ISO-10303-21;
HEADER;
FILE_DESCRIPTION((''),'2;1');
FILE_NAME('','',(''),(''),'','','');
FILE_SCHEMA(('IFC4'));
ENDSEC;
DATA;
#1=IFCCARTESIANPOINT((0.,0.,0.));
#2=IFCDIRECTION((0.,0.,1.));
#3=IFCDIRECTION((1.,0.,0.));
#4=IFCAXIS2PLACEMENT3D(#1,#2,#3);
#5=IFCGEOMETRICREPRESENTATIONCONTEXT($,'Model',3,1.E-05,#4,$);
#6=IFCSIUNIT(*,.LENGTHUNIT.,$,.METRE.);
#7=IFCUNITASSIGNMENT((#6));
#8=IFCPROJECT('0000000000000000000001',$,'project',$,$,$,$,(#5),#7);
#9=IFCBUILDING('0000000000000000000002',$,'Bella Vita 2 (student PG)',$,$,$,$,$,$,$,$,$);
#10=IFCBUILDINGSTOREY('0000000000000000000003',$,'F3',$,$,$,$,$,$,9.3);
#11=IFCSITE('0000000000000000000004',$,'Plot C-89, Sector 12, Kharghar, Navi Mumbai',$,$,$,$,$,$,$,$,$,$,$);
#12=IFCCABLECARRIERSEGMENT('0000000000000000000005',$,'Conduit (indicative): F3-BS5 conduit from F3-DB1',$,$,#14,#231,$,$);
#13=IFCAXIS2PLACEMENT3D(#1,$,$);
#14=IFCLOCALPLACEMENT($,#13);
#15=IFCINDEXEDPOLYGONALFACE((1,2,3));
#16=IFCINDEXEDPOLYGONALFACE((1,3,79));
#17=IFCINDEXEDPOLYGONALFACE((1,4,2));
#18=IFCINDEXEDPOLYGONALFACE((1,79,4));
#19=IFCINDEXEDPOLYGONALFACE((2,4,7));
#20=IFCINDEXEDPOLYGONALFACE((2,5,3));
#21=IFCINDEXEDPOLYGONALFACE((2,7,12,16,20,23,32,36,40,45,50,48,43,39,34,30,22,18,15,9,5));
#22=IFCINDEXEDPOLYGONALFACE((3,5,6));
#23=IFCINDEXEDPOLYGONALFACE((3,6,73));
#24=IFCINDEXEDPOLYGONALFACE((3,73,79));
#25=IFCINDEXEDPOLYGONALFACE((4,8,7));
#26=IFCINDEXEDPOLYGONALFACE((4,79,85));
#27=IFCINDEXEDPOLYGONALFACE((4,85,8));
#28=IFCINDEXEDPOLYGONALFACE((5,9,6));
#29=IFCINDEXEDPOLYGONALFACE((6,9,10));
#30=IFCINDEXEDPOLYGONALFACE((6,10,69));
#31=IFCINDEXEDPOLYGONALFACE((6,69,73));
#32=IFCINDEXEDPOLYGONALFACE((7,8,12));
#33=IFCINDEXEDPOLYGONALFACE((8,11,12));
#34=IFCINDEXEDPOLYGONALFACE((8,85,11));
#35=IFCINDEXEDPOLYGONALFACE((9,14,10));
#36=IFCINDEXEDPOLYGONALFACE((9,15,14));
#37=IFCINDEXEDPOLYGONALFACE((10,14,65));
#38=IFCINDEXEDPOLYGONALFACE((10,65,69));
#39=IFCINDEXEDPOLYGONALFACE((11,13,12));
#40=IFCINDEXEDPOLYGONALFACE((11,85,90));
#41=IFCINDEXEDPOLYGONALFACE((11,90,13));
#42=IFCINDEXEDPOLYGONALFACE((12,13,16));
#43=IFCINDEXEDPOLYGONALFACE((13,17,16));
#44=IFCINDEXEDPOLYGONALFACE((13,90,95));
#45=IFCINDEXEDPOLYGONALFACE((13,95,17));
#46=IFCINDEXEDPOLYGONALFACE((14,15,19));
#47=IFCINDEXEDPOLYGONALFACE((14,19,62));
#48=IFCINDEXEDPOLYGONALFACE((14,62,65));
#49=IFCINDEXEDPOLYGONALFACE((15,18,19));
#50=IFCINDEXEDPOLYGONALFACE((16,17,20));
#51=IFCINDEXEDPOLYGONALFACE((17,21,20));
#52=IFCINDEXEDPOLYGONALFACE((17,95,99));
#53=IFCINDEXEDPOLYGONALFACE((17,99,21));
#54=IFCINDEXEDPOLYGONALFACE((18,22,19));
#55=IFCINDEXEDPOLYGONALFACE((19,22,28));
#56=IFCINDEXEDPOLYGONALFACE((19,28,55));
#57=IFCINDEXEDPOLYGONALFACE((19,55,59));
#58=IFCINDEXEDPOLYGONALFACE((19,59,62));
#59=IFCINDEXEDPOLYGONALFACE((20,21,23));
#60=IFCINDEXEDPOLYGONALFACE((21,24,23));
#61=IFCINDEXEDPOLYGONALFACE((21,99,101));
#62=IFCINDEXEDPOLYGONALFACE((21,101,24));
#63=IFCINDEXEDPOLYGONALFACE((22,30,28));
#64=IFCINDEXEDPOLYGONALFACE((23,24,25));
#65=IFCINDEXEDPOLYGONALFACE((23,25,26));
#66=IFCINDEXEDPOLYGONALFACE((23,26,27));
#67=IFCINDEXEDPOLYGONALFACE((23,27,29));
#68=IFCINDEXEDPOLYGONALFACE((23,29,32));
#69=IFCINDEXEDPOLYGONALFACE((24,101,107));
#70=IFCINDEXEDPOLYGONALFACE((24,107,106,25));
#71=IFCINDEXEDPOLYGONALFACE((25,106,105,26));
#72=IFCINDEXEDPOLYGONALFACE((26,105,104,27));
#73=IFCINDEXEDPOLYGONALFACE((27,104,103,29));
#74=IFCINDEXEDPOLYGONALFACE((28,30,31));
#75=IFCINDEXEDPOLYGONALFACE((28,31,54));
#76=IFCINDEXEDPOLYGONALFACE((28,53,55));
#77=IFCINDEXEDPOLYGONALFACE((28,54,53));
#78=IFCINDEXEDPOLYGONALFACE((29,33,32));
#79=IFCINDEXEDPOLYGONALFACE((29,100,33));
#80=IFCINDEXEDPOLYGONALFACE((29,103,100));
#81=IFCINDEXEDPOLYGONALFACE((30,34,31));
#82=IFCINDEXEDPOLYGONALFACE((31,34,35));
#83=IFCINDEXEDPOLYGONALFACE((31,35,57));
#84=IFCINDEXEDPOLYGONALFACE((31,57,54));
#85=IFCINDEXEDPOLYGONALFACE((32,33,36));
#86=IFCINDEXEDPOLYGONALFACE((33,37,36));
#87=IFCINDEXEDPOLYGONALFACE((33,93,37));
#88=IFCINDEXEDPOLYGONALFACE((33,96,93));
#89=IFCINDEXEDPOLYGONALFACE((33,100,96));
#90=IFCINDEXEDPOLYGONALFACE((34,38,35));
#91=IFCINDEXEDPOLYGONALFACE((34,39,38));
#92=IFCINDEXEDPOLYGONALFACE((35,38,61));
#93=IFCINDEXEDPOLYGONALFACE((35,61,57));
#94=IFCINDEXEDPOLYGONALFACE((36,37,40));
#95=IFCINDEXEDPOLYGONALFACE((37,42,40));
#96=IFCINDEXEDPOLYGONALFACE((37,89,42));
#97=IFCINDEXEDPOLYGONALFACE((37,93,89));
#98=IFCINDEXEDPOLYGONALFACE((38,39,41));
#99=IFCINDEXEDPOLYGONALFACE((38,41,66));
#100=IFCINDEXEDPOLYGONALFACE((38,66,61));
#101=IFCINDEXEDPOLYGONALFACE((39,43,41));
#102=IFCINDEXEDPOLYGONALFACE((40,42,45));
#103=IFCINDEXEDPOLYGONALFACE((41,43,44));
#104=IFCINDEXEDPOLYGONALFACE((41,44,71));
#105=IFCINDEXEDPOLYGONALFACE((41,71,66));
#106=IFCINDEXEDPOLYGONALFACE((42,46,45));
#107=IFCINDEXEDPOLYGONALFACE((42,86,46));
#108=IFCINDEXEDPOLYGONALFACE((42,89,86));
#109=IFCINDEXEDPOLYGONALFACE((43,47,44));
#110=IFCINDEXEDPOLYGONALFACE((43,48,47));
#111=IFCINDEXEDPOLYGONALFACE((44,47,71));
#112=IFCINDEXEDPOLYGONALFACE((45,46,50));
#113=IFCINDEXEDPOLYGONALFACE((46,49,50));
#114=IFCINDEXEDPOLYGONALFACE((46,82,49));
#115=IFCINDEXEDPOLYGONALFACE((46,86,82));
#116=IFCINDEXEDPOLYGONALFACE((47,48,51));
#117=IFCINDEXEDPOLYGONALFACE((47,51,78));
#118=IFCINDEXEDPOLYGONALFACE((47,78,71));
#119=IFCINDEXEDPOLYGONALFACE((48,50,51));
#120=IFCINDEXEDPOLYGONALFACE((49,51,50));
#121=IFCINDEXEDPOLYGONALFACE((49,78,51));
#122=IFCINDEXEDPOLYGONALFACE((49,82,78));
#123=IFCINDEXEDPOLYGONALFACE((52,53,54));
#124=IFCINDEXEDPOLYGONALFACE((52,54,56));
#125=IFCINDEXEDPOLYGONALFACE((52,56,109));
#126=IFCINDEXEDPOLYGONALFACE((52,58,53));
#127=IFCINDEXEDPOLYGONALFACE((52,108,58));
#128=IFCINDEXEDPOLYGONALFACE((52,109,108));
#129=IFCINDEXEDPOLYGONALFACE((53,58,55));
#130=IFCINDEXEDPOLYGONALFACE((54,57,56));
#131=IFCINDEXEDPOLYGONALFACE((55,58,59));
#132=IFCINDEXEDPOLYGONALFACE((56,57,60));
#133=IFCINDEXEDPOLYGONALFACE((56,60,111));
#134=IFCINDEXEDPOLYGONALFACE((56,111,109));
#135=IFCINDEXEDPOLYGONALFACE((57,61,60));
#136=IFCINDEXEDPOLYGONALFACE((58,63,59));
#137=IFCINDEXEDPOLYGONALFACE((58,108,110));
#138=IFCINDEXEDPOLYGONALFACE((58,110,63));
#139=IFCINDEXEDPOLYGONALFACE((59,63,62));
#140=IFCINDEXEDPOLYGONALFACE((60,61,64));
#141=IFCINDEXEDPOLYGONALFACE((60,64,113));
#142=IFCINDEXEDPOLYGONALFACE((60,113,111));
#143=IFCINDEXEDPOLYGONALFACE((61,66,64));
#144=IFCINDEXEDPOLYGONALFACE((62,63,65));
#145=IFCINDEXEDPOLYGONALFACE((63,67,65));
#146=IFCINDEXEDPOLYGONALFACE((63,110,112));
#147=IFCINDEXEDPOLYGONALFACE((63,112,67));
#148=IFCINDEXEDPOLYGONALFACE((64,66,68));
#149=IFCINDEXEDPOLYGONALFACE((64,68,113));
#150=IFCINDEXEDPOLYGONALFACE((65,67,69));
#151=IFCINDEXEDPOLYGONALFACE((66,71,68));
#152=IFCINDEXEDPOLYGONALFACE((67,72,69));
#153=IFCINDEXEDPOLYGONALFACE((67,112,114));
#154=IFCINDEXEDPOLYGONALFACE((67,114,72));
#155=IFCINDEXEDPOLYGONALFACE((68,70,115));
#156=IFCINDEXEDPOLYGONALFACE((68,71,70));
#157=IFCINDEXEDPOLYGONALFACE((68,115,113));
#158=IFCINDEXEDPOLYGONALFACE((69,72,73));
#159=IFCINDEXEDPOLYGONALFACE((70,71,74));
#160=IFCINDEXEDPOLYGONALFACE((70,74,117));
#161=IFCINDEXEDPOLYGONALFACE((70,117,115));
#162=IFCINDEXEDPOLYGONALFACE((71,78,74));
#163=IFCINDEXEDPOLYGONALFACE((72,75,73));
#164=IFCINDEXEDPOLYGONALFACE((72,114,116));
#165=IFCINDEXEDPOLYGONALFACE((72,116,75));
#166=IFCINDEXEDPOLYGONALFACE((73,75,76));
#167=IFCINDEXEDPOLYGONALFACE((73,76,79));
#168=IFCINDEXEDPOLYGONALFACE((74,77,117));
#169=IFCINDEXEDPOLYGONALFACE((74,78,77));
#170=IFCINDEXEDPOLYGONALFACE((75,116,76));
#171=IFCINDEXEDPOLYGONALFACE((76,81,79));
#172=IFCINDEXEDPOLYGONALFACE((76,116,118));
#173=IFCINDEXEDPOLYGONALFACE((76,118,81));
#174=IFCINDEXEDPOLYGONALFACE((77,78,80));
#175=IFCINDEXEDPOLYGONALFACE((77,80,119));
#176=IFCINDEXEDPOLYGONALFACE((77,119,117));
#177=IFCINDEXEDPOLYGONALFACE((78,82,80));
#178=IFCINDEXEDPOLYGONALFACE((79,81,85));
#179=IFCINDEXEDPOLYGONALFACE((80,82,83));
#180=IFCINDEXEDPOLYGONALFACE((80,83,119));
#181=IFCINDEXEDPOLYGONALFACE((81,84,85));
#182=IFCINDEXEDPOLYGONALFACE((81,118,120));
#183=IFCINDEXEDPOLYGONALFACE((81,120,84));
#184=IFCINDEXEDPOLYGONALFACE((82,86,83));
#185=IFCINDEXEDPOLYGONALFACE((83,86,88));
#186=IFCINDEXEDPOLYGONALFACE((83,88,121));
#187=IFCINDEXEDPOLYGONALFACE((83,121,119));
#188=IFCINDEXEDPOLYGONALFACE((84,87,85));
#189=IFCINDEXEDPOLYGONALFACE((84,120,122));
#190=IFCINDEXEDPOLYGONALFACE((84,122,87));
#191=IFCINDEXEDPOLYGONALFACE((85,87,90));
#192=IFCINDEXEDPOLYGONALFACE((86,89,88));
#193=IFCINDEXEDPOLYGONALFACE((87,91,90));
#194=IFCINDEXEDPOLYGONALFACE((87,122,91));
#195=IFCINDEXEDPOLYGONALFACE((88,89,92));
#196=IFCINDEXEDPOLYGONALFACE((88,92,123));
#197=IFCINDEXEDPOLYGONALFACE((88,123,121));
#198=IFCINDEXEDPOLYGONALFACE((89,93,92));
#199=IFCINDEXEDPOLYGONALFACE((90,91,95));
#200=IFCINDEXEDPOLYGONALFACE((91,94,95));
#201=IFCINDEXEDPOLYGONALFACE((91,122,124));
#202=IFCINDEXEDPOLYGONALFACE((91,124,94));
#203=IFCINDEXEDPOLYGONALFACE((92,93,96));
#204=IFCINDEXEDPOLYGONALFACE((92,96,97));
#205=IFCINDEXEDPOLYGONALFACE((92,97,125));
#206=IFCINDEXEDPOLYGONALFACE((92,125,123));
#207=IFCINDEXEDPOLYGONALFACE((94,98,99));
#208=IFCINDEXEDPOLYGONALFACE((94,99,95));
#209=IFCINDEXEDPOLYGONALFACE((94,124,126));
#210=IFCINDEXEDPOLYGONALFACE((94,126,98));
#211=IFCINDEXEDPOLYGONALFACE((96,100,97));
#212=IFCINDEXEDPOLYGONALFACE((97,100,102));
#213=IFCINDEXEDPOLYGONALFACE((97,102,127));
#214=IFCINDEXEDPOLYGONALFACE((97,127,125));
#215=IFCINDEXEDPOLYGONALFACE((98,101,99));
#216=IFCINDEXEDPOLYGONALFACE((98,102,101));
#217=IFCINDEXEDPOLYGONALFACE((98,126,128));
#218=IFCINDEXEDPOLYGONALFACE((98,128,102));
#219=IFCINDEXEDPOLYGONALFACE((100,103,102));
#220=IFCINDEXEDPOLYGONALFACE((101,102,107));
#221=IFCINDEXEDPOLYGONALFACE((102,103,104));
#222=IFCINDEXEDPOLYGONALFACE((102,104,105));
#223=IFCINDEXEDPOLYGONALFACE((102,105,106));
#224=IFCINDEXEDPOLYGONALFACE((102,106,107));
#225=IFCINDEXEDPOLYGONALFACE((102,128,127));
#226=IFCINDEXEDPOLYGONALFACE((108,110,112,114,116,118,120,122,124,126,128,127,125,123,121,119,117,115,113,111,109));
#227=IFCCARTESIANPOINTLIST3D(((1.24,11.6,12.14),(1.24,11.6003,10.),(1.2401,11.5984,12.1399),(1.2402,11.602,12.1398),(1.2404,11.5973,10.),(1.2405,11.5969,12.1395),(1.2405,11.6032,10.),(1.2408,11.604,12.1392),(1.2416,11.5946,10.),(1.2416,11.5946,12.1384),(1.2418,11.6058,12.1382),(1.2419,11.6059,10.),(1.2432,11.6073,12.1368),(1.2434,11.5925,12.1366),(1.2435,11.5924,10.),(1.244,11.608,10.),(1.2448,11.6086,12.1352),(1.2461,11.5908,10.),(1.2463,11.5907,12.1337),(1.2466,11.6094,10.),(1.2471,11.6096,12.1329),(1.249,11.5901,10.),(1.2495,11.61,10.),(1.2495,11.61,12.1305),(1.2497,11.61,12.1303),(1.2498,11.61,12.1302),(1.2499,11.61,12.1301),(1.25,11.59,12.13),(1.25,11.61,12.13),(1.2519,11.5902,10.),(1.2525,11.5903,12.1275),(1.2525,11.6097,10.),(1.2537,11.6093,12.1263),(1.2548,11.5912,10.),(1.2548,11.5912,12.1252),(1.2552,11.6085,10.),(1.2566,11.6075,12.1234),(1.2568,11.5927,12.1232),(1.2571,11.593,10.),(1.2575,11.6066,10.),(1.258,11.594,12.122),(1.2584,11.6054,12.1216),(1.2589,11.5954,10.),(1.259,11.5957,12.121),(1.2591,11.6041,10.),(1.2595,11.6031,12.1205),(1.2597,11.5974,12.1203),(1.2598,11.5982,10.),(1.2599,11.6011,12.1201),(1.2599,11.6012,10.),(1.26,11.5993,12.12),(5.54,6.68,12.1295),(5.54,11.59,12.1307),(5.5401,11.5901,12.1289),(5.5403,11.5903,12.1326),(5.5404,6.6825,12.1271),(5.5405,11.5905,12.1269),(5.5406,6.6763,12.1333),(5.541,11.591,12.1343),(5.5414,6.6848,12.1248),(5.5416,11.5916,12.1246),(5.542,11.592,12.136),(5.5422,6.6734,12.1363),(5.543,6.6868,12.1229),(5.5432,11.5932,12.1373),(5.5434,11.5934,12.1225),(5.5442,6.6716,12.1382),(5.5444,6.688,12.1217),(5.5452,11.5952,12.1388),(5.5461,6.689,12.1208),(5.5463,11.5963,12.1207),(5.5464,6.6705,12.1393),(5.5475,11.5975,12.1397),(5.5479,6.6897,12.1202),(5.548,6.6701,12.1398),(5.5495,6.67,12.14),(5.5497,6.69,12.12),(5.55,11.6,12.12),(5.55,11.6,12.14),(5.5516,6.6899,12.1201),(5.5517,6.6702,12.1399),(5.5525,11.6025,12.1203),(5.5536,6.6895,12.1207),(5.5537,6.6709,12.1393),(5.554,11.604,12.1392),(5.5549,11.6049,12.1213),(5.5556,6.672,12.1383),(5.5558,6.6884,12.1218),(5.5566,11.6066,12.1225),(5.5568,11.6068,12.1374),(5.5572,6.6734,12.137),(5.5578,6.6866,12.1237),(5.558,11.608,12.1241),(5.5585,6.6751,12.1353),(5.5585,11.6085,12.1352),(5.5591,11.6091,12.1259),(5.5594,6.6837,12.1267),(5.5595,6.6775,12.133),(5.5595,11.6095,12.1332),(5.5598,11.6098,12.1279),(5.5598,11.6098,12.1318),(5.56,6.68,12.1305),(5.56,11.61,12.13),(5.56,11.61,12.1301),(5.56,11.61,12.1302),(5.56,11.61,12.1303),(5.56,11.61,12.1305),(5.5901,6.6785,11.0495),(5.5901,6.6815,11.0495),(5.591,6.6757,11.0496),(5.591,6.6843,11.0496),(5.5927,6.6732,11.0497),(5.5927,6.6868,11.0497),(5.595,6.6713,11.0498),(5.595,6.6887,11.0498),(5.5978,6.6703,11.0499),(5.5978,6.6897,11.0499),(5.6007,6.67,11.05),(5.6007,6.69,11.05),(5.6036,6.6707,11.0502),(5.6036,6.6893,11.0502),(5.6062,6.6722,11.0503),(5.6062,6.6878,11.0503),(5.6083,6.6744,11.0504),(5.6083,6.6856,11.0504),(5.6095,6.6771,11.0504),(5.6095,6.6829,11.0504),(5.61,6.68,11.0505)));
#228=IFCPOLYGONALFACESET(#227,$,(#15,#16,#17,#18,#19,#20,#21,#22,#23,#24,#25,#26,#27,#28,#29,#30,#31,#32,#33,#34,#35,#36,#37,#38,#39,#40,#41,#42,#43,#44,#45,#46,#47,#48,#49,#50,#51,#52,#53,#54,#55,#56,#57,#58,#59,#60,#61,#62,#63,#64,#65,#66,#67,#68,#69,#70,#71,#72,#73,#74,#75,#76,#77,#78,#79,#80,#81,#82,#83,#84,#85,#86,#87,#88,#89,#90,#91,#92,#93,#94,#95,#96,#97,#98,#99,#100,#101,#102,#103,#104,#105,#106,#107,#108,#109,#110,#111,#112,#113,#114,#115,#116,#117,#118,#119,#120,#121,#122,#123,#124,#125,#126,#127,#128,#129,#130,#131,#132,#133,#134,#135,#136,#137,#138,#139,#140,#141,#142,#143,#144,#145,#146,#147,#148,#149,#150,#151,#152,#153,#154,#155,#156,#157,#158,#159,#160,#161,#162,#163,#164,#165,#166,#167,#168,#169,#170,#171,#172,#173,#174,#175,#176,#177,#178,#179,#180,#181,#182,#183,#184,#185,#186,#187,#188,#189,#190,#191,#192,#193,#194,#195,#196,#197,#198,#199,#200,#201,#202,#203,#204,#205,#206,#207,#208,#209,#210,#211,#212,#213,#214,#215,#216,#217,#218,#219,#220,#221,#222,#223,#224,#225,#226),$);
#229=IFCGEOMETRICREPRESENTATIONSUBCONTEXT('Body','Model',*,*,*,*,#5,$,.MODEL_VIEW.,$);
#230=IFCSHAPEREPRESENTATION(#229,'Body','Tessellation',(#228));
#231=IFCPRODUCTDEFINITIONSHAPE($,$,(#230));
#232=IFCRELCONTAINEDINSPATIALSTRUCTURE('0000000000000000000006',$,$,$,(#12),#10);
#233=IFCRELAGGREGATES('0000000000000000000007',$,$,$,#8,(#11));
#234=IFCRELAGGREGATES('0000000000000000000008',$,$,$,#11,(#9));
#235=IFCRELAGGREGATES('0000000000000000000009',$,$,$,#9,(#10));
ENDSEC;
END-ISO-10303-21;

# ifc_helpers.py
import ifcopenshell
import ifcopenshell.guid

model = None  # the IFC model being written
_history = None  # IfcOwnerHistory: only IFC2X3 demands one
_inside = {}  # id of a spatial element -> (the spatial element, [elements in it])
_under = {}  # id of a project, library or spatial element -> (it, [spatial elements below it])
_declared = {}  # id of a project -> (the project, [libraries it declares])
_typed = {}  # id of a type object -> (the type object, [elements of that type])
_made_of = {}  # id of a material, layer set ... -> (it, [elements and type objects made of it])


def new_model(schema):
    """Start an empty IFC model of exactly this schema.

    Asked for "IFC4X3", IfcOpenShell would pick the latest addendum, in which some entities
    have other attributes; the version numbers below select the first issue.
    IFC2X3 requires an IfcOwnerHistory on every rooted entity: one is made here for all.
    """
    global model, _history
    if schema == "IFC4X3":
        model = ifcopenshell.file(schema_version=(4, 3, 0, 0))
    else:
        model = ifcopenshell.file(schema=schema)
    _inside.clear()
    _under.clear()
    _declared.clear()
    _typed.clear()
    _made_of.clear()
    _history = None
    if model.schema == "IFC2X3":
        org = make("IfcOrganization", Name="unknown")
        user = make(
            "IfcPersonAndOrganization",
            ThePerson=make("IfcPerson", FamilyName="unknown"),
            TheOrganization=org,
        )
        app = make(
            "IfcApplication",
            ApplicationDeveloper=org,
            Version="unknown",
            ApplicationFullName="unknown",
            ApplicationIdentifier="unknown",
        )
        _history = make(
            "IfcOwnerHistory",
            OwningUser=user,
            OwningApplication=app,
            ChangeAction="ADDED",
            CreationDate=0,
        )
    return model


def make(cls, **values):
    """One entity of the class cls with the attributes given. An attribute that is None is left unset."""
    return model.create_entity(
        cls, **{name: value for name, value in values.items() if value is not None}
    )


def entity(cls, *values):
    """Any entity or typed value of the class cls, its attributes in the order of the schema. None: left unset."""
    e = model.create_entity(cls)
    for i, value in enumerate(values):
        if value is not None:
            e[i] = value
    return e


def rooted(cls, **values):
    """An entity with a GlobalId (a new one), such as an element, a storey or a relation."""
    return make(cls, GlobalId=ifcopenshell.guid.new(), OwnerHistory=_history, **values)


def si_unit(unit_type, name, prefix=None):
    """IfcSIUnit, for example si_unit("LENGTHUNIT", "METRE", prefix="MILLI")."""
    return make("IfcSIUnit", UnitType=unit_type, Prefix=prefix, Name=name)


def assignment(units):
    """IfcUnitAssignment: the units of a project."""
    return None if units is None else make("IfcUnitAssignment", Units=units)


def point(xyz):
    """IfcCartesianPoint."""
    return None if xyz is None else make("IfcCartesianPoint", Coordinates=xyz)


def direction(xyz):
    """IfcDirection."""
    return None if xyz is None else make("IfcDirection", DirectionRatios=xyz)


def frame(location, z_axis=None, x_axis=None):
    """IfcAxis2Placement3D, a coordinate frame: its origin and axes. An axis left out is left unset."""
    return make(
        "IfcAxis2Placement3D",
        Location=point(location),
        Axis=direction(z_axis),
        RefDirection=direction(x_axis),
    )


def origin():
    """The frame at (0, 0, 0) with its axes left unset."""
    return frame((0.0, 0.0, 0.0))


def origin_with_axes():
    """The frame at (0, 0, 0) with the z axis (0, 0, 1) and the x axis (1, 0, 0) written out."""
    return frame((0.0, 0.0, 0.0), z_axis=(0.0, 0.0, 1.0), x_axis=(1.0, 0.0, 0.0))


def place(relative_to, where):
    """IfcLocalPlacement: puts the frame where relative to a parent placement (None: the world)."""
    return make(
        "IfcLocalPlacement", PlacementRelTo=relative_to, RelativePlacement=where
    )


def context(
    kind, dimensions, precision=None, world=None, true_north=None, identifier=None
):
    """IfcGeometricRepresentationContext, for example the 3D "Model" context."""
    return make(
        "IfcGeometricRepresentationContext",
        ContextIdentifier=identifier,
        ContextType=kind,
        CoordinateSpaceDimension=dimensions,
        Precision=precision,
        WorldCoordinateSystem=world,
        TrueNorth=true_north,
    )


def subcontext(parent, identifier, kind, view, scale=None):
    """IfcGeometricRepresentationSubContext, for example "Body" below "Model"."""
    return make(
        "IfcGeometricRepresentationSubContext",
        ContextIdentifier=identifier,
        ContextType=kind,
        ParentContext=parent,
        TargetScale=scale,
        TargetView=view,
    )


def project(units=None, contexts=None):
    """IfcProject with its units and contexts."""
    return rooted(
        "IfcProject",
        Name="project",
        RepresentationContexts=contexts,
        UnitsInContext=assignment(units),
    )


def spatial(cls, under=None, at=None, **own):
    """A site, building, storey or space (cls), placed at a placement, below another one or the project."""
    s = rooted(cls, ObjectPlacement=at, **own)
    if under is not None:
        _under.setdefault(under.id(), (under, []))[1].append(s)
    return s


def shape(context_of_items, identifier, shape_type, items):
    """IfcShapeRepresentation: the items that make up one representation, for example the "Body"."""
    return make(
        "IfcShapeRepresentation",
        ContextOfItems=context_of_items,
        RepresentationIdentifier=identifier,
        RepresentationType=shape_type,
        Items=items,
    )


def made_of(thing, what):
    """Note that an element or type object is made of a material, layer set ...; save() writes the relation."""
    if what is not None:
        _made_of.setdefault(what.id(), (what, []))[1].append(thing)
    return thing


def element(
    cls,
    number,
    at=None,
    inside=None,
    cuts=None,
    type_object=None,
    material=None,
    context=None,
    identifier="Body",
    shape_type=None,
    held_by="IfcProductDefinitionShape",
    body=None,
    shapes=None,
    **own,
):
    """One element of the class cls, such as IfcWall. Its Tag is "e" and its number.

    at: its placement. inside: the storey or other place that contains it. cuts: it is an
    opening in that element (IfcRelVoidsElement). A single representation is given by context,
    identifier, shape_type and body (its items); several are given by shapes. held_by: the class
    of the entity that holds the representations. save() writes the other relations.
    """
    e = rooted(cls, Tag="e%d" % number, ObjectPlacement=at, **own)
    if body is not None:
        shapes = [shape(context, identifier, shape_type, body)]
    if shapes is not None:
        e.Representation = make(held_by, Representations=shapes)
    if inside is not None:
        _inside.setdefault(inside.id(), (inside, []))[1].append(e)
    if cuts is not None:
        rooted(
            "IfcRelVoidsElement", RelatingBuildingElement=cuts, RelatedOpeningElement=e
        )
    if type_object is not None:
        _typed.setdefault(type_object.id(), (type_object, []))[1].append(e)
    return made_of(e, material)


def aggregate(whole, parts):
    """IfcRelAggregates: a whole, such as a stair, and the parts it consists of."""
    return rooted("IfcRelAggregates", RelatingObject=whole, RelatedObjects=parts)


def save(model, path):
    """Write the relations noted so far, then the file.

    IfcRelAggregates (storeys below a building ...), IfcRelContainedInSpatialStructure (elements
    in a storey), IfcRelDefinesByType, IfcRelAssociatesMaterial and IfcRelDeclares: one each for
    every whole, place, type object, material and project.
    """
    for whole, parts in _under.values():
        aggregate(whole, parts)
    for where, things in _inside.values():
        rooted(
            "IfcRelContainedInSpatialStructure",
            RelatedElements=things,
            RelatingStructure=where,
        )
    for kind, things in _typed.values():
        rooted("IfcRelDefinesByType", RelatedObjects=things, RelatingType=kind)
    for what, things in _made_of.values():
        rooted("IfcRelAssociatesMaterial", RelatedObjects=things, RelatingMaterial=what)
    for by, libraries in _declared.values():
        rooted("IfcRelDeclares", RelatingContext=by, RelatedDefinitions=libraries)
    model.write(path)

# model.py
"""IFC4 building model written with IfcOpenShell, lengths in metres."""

from ifc_helpers import new_model, entity, si_unit, origin, origin_with_axes, place, context, subcontext, project, spatial, element, save


model = new_model("IFC4")

# Units and contexts
model_context = context("Model", 3, precision=1e-05, world=origin_with_axes())
body_context = subcontext(model_context, "Body", "Model", "MODEL_VIEW")
ifc_project = project(units=[si_unit("LENGTHUNIT", "METRE")], contexts=[model_context])

# Site, building, storey
site = spatial("IfcSite", under=ifc_project, Name="Plot C-89, Sector 12, Kharghar, Navi Mumbai")
building = spatial("IfcBuilding", under=site, Name="Bella Vita 2 (student PG)")
storey = spatial("IfcBuildingStorey", under=building, Name="F3", Elevation=9.3)

# Cable carrier segment
cable_carrier_segment_1_placement = place(None, origin())
element("IfcCableCarrierSegment", 1, at=cable_carrier_segment_1_placement, inside=storey, Name="Conduit (indicative): F3-BS5 conduit from F3-DB1", context=body_context, shape_type="AdvancedSweptSolid", body=[
    entity("IfcSweptDiskSolid", entity("IfcPolyline", [entity("IfcCartesianPoint", [5.6, 6.68, 11.05]), entity("IfcCartesianPoint", [5.55, 6.68, 12.13]), entity("IfcCartesianPoint", [5.55, 11.6, 12.13]), entity("IfcCartesianPoint", [1.25, 11.6, 12.13]), entity("IfcCartesianPoint", [1.25, 11.6, 10.0])]), 0.01),
])

save(model, "model.ifc")
